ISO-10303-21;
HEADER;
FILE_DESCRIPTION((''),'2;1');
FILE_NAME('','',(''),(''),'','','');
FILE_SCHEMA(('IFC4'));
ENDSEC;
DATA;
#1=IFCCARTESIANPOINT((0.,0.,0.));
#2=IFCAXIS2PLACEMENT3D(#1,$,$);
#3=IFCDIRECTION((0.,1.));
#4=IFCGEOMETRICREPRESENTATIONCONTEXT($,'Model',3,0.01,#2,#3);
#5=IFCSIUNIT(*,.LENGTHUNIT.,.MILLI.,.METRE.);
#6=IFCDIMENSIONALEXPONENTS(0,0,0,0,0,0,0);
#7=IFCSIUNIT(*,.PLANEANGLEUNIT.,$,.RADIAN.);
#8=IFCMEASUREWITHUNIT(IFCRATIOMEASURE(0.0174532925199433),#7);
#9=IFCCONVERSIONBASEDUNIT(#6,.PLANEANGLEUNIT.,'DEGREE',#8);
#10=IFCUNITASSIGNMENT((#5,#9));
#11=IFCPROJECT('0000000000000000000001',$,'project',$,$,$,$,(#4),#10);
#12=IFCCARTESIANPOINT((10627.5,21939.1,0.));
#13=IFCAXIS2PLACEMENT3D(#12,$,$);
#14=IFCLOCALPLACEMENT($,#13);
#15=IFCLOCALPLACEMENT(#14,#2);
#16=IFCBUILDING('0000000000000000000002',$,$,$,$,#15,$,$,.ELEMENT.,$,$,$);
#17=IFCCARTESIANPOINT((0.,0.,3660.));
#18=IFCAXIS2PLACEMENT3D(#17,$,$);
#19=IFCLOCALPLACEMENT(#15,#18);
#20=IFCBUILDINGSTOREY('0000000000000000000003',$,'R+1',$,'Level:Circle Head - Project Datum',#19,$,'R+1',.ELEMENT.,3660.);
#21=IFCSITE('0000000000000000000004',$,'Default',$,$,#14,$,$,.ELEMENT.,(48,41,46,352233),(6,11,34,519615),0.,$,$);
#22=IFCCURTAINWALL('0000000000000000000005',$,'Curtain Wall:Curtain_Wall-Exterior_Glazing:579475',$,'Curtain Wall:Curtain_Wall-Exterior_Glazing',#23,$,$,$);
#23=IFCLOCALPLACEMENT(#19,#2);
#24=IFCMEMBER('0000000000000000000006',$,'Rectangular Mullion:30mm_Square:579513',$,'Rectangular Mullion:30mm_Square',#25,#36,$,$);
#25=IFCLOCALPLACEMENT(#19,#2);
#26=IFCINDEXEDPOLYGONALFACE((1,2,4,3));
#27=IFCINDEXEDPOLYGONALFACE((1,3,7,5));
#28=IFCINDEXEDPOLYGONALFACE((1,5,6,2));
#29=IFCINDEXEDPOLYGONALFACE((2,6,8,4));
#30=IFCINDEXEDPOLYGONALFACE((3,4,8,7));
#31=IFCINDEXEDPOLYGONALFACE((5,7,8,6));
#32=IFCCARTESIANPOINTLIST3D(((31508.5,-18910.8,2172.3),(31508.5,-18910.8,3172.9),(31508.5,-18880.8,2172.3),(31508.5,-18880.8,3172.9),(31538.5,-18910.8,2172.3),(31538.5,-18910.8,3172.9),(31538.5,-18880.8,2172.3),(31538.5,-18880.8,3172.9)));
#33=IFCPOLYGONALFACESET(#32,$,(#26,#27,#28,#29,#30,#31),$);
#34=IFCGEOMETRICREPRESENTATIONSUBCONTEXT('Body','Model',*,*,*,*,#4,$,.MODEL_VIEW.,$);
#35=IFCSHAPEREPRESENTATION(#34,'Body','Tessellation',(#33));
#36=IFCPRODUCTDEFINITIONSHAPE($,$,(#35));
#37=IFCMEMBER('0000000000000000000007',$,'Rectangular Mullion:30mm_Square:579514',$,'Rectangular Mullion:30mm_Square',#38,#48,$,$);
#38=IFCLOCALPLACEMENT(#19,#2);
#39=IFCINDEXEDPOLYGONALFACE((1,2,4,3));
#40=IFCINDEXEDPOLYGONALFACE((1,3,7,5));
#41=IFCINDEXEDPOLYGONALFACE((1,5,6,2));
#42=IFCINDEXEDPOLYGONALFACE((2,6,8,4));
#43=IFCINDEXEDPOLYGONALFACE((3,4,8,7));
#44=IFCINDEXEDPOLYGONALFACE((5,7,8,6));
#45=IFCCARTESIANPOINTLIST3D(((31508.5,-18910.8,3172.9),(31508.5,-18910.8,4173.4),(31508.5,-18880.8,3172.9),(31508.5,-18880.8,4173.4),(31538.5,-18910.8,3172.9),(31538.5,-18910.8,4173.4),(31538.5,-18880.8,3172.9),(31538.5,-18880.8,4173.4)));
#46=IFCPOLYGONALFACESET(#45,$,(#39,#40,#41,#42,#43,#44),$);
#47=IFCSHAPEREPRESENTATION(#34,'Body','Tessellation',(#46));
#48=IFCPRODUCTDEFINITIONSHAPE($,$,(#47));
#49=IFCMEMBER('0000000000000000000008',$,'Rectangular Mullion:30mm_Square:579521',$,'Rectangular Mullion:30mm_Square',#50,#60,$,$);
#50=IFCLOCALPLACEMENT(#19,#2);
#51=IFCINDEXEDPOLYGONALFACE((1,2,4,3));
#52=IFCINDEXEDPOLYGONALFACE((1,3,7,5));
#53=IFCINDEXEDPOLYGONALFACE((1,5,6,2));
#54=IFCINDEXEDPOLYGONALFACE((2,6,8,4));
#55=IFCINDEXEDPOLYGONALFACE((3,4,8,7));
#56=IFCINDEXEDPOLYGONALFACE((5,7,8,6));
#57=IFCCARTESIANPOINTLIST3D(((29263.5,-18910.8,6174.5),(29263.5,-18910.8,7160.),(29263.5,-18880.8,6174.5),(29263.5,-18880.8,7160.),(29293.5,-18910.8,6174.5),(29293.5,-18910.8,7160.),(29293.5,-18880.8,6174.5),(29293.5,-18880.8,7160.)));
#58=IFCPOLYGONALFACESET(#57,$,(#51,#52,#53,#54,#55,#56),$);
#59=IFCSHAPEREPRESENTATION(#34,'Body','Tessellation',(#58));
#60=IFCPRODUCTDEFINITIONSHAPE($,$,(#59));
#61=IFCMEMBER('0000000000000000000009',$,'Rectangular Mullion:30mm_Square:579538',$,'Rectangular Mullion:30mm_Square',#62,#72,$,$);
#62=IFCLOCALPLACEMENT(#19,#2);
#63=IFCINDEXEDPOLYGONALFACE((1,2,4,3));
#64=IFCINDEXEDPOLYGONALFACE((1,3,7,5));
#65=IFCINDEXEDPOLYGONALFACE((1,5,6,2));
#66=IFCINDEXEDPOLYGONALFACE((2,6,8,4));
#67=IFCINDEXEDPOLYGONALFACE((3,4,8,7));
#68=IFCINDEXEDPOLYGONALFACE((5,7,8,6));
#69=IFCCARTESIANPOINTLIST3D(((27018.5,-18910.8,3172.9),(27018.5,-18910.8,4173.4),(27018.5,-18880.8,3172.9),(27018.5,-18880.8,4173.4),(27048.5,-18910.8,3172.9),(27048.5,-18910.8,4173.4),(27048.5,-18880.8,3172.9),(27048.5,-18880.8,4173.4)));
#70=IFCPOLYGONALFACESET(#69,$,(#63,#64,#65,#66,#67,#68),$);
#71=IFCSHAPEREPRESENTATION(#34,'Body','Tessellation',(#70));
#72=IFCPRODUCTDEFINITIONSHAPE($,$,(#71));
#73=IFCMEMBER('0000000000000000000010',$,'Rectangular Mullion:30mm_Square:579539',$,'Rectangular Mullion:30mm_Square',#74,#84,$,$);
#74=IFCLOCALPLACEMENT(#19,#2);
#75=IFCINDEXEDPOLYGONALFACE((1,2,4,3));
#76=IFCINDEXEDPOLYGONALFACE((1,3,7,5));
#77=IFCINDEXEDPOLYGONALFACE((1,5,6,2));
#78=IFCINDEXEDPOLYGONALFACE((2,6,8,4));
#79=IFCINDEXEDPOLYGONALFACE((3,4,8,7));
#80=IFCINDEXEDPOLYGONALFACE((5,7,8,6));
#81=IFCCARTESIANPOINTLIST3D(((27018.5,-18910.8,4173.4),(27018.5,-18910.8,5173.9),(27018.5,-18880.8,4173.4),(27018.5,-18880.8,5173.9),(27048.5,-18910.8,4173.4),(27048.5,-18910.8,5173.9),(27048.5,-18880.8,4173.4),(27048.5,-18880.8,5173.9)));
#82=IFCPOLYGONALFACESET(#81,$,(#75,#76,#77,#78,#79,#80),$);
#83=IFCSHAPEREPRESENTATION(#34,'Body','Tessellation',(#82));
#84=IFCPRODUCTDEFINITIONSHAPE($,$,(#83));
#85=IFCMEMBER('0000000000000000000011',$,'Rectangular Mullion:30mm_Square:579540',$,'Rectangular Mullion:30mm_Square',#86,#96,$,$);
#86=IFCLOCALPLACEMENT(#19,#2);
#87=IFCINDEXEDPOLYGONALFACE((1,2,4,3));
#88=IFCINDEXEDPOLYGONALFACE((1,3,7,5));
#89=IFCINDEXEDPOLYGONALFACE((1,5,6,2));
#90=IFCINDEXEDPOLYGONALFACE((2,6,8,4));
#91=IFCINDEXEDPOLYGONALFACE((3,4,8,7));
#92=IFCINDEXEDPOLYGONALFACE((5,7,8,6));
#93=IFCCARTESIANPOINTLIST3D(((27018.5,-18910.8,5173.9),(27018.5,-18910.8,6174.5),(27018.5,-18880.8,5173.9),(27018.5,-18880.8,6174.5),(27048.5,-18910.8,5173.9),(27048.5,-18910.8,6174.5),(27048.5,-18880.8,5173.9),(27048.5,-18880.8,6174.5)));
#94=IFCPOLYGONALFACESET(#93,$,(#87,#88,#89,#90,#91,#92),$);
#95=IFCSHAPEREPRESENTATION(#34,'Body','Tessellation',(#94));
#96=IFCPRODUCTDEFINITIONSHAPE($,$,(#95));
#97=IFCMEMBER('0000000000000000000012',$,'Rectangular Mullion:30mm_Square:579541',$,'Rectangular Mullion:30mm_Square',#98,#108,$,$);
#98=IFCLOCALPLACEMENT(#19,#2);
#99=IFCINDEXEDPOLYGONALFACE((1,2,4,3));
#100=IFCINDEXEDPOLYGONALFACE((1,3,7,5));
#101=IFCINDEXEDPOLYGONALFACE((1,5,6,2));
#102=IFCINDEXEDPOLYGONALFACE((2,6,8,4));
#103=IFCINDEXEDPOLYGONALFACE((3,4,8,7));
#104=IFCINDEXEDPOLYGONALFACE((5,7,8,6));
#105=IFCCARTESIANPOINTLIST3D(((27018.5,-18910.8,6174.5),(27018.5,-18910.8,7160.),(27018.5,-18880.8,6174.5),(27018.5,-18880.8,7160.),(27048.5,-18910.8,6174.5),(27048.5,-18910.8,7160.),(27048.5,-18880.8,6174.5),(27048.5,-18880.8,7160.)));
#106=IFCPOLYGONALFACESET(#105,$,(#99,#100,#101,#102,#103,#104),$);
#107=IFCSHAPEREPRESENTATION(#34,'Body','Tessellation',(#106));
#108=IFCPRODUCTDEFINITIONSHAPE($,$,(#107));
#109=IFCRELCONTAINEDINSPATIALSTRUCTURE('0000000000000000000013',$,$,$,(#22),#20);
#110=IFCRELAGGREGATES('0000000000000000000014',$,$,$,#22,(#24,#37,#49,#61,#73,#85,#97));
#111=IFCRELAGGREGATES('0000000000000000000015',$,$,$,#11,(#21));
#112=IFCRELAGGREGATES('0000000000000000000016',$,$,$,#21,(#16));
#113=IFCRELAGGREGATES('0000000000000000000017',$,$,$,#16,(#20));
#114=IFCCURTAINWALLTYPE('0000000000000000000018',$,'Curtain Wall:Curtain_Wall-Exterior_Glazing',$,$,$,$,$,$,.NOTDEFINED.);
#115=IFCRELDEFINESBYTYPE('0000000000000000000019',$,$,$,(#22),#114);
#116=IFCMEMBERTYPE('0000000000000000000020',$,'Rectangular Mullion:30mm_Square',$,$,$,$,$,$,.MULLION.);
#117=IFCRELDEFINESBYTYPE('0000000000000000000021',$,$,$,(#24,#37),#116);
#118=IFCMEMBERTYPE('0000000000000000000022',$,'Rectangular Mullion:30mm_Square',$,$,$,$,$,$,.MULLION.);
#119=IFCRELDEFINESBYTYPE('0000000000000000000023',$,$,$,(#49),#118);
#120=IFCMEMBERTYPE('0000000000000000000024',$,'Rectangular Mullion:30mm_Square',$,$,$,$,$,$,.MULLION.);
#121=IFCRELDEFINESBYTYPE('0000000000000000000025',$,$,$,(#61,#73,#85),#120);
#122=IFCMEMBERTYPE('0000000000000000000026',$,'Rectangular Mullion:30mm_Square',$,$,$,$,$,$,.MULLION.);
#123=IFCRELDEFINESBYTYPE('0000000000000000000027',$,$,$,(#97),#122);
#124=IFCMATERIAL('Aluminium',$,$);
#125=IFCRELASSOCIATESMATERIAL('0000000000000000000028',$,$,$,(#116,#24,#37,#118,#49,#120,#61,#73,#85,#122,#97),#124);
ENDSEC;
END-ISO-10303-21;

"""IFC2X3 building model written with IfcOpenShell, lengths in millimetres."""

from ifc_helpers import new_model, entity, si_unit, converted_unit, direction, frame, origin, origin_2d_with_axis, place, context, subcontext, project, spatial, rectangle, extrude, source, transform, mapped, material, type_object, type_shapes, element, aggregate, save


model = new_model("IFC2X3")

# Units and contexts
model_context = context("Model", 3, precision=0.01, world=origin(), true_north=direction((0.0, 1.0)))
body_context = subcontext(model_context, "Body", "Model", "MODEL_VIEW")
ifc_project = project(units=[si_unit("LENGTHUNIT", "METRE", prefix="MILLI"), converted_unit("PLANEANGLEUNIT", "DEGREE", entity("IfcRatioMeasure", 0.0174532925199433), si_unit("PLANEANGLEUNIT", "RADIAN"), dimensions=[0, 0, 0, 0, 0, 0, 0])], contexts=[model_context])

# Site, building, storey
site_placement = place(None, frame((10627.5, 21939.1, 0.0)))
site = spatial("IfcSite", under=ifc_project, at=site_placement, Name="Default", CompositionType="ELEMENT", RefLatitude=(48, 41, 46, 352233), RefLongitude=(6, 11, 34, 519615), RefElevation=0.0)
building_placement = place(site_placement, origin())
building = spatial("IfcBuilding", under=site, at=building_placement, CompositionType="ELEMENT")
storey_placement = place(building_placement, frame((0.0, 0.0, 3660.0)))
storey = spatial("IfcBuildingStorey", under=building, at=storey_placement, Name="R+1", ObjectType="Level:Circle Head - Project Datum", LongName="R+1", CompositionType="ELEMENT", Elevation=3660.0)

# Curtain wall, members
curtain_wall_type = type_object("IfcCurtainWallType", Name="Curtain Wall:Curtain_Wall-Exterior_Glazing", PredefinedType="NOTDEFINED")
curtain_wall_placement = place(storey_placement, frame((0.0, 0.0, -3660.0)))
curtain_wall = element("IfcCurtainWall", 1, at=curtain_wall_placement, inside=storey, type_object=curtain_wall_type, Name="Curtain Wall:Curtain_Wall-Exterior_Glazing:579475", ObjectType="Curtain Wall:Curtain_Wall-Exterior_Glazing")
ifc_material_1 = material(Name="Aluminium")
member_type_1 = type_object("IfcMemberType", Name="Rectangular Mullion:30mm_Square", PredefinedType="MULLION", material=ifc_material_1)
shared_shape_1 = source(origin(), body_context, "Body", "SweptSolid", [
    extrude(rectangle(XDim=30.0, YDim=30.0, at=origin_2d_with_axis()), frame((-15.0, 0.0, -1000.5), z_axis=(0.0, 0.0, 1.0), x_axis=(0.0, -1.0, 0.0)), (0.0, 0.0, 1.0), 1000.5),
])
type_shapes(member_type_1, [shared_shape_1])
member_1_placement = place(storey_placement, frame((31538.5, -18895.8, 3172.9)))
member_1 = element("IfcMember", 2, at=member_1_placement, type_object=member_type_1, material=ifc_material_1, Name="Rectangular Mullion:30mm_Square:579513", ObjectType="Rectangular Mullion:30mm_Square", context=body_context, shape_type="MappedRepresentation", body=[
    mapped(shared_shape_1, transform((0.0, 0.0, 0.0), scale=1.0)),
])
member_2_placement = place(storey_placement, frame((31538.5, -18895.8, 4173.4)))
member_2 = element("IfcMember", 3, at=member_2_placement, type_object=member_type_1, material=ifc_material_1, Name="Rectangular Mullion:30mm_Square:579514", ObjectType="Rectangular Mullion:30mm_Square", context=body_context, shape_type="MappedRepresentation", body=[
    mapped(shared_shape_1, transform((0.0, 0.0, 0.0), scale=1.0)),
])
member_type_2 = type_object("IfcMemberType", Name="Rectangular Mullion:30mm_Square", PredefinedType="MULLION", material=ifc_material_1)
shared_shape_2 = source(origin(), body_context, "Body", "SweptSolid", [
    extrude(rectangle(XDim=30.0, YDim=30.0, at=origin_2d_with_axis()), frame((0.0, 0.0, -985.5), z_axis=(0.0, 0.0, 1.0), x_axis=(0.0, -1.0, 0.0)), (0.0, 0.0, 1.0), 985.5),
])
type_shapes(member_type_2, [shared_shape_2])
member_3_placement = place(storey_placement, frame((29278.5, -18895.8, 6174.5), z_axis=(0.0, 0.0, -1.0), x_axis=(-1.0, 0.0, 0.0)))
member_3 = element("IfcMember", 4, at=member_3_placement, type_object=member_type_2, material=ifc_material_1, Name="Rectangular Mullion:30mm_Square:579521", ObjectType="Rectangular Mullion:30mm_Square", context=body_context, shape_type="MappedRepresentation", body=[
    mapped(shared_shape_2, transform((0.0, 0.0, 0.0), scale=1.0)),
])
member_type_3 = type_object("IfcMemberType", Name="Rectangular Mullion:30mm_Square", PredefinedType="MULLION", material=ifc_material_1)
shared_shape_3 = source(origin(), body_context, "Body", "SweptSolid", [
    extrude(rectangle(XDim=30.0, YDim=30.0, at=origin_2d_with_axis()), frame((-15.0, 0.0, -1000.5), z_axis=(0.0, 0.0, 1.0), x_axis=(0.0, -1.0, 0.0)), (0.0, 0.0, 1.0), 1000.5),
])
type_shapes(member_type_3, [shared_shape_3])
member_4_placement = place(storey_placement, frame((27018.5, -18895.8, 3172.9), z_axis=(0.0, 0.0, -1.0), x_axis=(-1.0, 0.0, 0.0)))
member_4 = element("IfcMember", 5, at=member_4_placement, type_object=member_type_3, material=ifc_material_1, Name="Rectangular Mullion:30mm_Square:579538", ObjectType="Rectangular Mullion:30mm_Square", context=body_context, shape_type="MappedRepresentation", body=[
    mapped(shared_shape_3, transform((0.0, 0.0, 0.0), scale=1.0)),
])
member_5_placement = place(storey_placement, frame((27018.5, -18895.8, 4173.4), z_axis=(0.0, 0.0, -1.0), x_axis=(-1.0, 0.0, 0.0)))
member_5 = element("IfcMember", 6, at=member_5_placement, type_object=member_type_3, material=ifc_material_1, Name="Rectangular Mullion:30mm_Square:579539", ObjectType="Rectangular Mullion:30mm_Square", context=body_context, shape_type="MappedRepresentation", body=[
    mapped(shared_shape_3, transform((0.0, 0.0, 0.0), scale=1.0)),
])
member_6_placement = place(storey_placement, frame((27018.5, -18895.8, 5173.9), z_axis=(0.0, 0.0, -1.0), x_axis=(-1.0, 0.0, 0.0)))
member_6 = element("IfcMember", 7, at=member_6_placement, type_object=member_type_3, material=ifc_material_1, Name="Rectangular Mullion:30mm_Square:579540", ObjectType="Rectangular Mullion:30mm_Square", context=body_context, shape_type="MappedRepresentation", body=[
    mapped(shared_shape_3, transform((0.0, 0.0, 0.0), scale=1.0)),
])
member_type_4 = type_object("IfcMemberType", Name="Rectangular Mullion:30mm_Square", PredefinedType="MULLION", material=ifc_material_1)
shared_shape_4 = source(origin(), body_context, "Body", "SweptSolid", [
    extrude(rectangle(XDim=30.0, YDim=30.0, at=origin_2d_with_axis()), frame((-15.0, 0.0, -985.5), z_axis=(0.0, 0.0, 1.0), x_axis=(0.0, -1.0, 0.0)), (0.0, 0.0, 1.0), 985.5),
])
type_shapes(member_type_4, [shared_shape_4])
member_7_placement = place(storey_placement, frame((27018.5, -18895.8, 6174.5), z_axis=(0.0, 0.0, -1.0), x_axis=(-1.0, 0.0, 0.0)))
member_7 = element("IfcMember", 8, at=member_7_placement, type_object=member_type_4, material=ifc_material_1, Name="Rectangular Mullion:30mm_Square:579541", ObjectType="Rectangular Mullion:30mm_Square", context=body_context, shape_type="MappedRepresentation", body=[
    mapped(shared_shape_4, transform((0.0, 0.0, 0.0), scale=1.0)),
])
aggregate(curtain_wall, [member_1, member_2, member_3, member_4, member_5, member_6, member_7])

save(model, "model.ifc")
